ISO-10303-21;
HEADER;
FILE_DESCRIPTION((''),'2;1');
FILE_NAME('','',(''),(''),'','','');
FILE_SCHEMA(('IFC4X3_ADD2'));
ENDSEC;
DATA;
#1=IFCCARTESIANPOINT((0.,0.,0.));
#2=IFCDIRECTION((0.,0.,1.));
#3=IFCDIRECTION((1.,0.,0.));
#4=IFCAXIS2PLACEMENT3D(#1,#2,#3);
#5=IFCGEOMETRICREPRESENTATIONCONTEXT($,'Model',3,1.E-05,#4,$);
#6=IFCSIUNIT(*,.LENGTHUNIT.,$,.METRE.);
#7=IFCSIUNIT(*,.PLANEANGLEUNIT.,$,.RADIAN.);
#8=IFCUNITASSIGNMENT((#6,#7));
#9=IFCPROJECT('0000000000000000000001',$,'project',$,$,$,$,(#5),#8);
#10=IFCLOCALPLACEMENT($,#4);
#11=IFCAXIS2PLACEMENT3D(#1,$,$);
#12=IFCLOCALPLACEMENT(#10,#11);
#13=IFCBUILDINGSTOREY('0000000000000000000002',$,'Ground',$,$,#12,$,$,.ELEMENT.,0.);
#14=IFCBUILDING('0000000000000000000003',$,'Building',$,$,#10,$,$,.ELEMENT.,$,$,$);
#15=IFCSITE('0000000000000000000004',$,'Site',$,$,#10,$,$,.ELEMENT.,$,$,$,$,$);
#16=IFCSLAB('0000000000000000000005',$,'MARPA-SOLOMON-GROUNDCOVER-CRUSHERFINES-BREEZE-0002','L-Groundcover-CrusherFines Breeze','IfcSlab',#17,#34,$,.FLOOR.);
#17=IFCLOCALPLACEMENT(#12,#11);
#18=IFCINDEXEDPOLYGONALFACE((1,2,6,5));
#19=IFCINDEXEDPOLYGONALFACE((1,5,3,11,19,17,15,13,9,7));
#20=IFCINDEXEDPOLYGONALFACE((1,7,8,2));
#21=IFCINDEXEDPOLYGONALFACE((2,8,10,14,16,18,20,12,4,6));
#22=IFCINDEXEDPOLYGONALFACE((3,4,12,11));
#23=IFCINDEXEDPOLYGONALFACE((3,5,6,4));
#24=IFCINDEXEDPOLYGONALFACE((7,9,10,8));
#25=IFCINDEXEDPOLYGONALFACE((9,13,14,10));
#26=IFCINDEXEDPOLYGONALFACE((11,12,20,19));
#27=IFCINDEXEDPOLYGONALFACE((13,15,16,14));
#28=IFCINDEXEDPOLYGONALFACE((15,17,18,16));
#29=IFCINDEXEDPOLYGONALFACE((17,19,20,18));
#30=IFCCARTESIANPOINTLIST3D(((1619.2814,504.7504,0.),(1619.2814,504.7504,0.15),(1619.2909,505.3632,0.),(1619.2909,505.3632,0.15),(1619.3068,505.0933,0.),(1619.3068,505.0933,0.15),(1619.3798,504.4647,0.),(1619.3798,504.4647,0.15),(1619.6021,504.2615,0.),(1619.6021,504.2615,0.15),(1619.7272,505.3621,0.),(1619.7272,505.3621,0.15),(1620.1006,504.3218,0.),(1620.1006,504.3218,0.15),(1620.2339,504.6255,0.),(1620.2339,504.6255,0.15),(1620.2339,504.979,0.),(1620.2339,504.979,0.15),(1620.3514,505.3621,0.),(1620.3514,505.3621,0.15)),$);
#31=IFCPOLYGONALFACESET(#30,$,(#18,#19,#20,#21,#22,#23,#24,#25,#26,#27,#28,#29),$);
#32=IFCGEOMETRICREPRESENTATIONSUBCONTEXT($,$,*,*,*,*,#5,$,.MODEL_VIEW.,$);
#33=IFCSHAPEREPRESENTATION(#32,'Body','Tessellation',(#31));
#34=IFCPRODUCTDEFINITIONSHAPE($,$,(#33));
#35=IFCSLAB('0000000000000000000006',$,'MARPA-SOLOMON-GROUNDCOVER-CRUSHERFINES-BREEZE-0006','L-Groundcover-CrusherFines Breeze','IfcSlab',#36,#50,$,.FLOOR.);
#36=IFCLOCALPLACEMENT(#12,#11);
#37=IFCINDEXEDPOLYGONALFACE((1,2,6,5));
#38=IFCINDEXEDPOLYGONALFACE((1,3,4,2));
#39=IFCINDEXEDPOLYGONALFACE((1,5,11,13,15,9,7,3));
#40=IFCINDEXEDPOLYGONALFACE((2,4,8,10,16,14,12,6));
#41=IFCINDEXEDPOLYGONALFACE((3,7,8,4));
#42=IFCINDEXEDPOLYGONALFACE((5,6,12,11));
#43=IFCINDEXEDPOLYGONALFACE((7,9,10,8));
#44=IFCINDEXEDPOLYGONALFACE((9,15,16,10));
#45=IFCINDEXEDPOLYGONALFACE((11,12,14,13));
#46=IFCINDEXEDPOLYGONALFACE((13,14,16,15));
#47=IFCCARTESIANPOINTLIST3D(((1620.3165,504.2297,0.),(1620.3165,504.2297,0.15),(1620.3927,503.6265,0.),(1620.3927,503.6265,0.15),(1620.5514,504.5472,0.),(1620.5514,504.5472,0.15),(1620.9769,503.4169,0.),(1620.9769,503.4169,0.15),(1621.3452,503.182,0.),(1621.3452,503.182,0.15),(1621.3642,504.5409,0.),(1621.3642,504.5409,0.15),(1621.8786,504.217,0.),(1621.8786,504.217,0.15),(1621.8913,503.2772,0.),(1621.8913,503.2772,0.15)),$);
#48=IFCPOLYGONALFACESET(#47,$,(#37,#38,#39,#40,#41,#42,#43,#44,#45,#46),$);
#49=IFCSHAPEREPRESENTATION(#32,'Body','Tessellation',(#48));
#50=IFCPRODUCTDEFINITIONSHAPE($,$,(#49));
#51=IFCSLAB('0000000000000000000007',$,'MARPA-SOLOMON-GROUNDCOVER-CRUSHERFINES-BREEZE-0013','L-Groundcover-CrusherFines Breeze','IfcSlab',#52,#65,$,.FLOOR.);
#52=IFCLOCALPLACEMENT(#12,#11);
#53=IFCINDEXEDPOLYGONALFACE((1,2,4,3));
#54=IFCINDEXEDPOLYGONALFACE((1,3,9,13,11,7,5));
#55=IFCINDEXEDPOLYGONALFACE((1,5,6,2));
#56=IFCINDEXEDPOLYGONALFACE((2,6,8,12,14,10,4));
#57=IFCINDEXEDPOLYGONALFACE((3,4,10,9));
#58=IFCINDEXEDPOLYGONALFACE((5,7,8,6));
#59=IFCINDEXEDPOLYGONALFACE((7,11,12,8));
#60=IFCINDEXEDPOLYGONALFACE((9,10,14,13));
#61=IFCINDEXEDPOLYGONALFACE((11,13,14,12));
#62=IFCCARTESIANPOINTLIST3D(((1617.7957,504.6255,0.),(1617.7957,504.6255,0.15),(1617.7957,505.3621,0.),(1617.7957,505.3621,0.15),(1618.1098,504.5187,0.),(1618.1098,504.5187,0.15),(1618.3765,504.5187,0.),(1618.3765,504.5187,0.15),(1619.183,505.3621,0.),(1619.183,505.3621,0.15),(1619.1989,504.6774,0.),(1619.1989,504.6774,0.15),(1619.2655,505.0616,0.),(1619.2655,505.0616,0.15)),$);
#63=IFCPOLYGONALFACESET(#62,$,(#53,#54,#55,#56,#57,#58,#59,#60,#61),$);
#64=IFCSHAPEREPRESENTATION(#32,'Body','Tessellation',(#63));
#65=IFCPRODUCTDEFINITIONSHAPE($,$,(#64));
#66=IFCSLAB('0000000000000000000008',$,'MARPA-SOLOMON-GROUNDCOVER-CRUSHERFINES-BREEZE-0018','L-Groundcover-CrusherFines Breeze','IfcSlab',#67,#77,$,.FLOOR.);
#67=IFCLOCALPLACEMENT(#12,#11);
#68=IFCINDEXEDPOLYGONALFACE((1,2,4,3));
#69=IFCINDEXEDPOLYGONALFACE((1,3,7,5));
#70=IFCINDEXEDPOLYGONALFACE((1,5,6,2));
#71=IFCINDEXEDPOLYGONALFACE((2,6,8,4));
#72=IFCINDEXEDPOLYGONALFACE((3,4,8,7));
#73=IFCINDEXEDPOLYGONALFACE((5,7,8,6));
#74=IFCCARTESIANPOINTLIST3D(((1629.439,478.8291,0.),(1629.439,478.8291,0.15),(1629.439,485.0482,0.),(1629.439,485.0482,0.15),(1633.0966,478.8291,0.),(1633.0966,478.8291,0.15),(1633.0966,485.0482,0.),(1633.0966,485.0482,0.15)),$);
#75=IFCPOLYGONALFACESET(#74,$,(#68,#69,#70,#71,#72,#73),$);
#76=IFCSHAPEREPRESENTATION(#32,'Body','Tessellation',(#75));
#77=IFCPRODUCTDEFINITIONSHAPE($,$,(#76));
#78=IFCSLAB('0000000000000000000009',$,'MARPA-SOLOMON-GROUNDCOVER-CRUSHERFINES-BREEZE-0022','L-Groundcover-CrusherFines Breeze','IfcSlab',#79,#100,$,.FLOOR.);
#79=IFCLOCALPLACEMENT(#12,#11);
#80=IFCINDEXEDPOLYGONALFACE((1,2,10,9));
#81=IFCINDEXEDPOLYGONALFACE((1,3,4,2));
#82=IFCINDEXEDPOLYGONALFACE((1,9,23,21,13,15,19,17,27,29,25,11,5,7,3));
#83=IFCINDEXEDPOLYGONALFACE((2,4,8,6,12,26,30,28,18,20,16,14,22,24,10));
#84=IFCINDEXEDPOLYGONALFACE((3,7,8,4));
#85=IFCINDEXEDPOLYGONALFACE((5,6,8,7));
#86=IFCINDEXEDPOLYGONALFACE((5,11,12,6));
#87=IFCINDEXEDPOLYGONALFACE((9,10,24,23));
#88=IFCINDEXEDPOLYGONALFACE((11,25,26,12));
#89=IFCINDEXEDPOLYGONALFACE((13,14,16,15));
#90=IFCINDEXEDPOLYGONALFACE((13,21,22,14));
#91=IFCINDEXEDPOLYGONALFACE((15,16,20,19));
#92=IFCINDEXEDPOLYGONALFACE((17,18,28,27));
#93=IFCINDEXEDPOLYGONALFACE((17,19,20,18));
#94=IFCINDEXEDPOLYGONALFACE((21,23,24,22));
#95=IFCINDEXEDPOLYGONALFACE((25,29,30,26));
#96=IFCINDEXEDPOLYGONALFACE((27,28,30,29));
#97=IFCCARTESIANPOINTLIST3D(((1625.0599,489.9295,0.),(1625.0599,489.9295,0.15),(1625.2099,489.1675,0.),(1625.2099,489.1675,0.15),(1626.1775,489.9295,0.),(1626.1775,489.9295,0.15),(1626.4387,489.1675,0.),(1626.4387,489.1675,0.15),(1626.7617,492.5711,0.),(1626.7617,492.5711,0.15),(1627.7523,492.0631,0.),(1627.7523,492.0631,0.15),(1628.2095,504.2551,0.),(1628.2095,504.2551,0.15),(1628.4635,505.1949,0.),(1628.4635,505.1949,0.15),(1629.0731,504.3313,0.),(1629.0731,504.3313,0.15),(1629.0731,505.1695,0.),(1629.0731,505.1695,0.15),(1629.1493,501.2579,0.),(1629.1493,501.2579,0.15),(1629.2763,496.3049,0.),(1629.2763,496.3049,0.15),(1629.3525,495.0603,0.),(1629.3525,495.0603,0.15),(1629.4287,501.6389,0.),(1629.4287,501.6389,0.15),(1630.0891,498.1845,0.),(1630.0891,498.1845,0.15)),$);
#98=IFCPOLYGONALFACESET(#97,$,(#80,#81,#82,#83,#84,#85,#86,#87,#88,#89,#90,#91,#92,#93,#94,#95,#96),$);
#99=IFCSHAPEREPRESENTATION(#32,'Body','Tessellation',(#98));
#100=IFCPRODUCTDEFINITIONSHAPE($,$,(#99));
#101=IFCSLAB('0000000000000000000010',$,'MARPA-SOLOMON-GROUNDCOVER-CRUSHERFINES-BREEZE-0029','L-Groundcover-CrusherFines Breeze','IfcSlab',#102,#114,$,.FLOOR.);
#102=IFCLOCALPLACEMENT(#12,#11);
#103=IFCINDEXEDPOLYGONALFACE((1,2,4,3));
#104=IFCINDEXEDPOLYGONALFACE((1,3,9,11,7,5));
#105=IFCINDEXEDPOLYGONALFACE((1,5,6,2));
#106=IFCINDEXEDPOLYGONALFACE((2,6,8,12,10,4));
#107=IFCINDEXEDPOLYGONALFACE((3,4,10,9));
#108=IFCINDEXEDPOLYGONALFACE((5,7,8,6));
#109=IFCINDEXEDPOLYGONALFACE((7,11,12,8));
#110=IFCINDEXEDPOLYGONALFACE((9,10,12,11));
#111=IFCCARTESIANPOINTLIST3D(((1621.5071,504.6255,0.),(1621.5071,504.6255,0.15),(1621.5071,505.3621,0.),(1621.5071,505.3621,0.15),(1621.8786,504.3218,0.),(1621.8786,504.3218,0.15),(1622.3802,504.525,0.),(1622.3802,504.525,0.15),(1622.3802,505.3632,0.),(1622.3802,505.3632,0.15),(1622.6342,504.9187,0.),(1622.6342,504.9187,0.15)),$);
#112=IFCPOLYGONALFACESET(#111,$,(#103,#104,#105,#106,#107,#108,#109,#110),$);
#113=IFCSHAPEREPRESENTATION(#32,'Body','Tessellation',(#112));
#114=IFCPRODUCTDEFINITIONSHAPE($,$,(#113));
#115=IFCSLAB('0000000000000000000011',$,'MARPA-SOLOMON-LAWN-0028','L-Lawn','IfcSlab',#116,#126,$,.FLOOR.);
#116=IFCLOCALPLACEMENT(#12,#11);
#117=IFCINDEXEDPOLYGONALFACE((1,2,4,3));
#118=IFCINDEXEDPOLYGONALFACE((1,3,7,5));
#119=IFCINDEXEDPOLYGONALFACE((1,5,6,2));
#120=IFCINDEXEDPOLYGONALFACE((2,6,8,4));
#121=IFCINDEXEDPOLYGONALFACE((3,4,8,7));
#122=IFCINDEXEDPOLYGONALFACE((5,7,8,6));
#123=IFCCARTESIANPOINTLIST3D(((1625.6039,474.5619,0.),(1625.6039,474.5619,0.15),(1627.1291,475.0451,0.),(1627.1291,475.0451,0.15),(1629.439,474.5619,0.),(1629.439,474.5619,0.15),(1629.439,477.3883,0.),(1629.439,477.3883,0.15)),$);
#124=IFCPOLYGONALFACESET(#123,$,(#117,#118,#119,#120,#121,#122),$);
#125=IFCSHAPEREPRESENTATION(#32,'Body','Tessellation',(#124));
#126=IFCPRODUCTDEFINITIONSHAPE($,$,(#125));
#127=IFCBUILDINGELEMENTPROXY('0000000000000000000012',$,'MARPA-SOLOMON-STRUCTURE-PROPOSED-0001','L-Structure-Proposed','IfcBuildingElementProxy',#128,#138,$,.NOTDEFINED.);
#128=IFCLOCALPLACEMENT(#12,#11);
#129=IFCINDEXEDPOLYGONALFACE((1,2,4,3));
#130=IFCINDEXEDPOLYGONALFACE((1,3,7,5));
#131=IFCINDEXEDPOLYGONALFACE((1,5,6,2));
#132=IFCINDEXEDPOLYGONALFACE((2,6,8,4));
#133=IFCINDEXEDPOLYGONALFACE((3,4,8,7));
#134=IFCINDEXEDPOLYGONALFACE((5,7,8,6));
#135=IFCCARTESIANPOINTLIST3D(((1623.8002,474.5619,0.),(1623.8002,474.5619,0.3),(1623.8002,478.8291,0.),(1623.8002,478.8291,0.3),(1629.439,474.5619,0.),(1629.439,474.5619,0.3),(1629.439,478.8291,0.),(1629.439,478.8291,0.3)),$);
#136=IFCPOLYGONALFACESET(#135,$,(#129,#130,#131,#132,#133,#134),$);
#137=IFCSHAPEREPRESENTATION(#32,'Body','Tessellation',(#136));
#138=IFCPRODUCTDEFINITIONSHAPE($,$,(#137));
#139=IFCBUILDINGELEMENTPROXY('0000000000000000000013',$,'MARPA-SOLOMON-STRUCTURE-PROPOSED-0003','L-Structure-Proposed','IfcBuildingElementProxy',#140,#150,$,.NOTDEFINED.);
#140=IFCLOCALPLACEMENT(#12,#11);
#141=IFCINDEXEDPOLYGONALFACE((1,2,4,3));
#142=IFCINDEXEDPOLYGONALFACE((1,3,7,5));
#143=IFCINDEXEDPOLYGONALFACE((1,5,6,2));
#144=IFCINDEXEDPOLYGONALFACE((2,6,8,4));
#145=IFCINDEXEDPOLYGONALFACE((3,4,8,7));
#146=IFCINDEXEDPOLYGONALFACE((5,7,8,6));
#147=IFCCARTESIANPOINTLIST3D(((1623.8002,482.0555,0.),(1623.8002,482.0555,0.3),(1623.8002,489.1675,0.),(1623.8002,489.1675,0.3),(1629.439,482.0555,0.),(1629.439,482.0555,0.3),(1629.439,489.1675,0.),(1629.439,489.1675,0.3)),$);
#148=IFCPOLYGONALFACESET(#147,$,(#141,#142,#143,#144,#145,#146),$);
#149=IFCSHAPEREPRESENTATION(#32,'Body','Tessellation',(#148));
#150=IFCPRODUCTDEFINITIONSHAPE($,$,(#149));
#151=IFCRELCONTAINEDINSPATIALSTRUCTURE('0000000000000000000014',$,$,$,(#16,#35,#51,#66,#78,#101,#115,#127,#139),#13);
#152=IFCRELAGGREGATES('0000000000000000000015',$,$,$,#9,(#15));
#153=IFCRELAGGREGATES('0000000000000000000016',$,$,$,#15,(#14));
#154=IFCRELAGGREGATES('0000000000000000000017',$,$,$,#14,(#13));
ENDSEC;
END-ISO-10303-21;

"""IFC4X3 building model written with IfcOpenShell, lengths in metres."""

from ifc_helpers import new_model, si_unit, frame, origin, origin_with_axes, place, context, subcontext, project, spatial, polyline, outline, extrude, element, save


model = new_model("IFC4X3")

# Units and contexts
model_context = context("Model", 3, precision=1e-05, world=origin_with_axes())
sub_context = subcontext(model_context, None, None, "MODEL_VIEW")
ifc_project = project(units=[si_unit("LENGTHUNIT", "METRE"), si_unit("PLANEANGLEUNIT", "RADIAN")], contexts=[model_context])

# Site, building, storey
placement = place(None, origin_with_axes())
site = spatial("IfcSite", under=ifc_project, at=placement, Name="Site", CompositionType="ELEMENT")
building = spatial("IfcBuilding", under=site, at=placement, Name="Building", CompositionType="ELEMENT")
storey_placement = place(placement, origin())
storey = spatial("IfcBuildingStorey", under=building, at=storey_placement, Name="Ground", CompositionType="ELEMENT", Elevation=0.0)

# Slabs
slab_1_placement = place(storey_placement, frame((1619.2814, 504.2615, 0.0)))
element("IfcSlab", 1, at=slab_1_placement, inside=storey, Name="MARPA-SOLOMON-GROUNDCOVER-CRUSHERFINES-BREEZE-0002", Description="L-Groundcover-CrusherFines Breeze", ObjectType="IfcSlab", PredefinedType="FLOOR", context=sub_context, shape_type="SweptSolid", body=[
    extrude(outline(polyline([(1.07, 1.1006), (0.9525, 0.7175), (0.9525, 0.364), (0.8192, 0.0603), (0.3207, 0.0), (0.0984, 0.2032), (0.0, 0.4889), (0.0254, 0.8318), (0.0095, 1.1017), (0.4458, 1.1006), (1.07, 1.1006)])), origin(), (0.0, 0.0, 1.0), 0.15),
])
slab_2_placement = place(storey_placement, frame((1620.3165, 503.182, 0.0)))
element("IfcSlab", 2, at=slab_2_placement, inside=storey, Name="MARPA-SOLOMON-GROUNDCOVER-CRUSHERFINES-BREEZE-0006", Description="L-Groundcover-CrusherFines Breeze", ObjectType="IfcSlab", PredefinedType="FLOOR", context=sub_context, shape_type="SweptSolid", body=[
    extrude(outline(polyline([(1.0477, 1.3589), (0.2349, 1.3653), (0.0, 1.0478), (0.0762, 0.4445), (0.6604, 0.2349), (1.0287, 0.0), (1.5748, 0.0952), (1.5621, 1.035), (1.0477, 1.3589)])), origin(), (0.0, 0.0, 1.0), 0.15),
])
slab_3_placement = place(storey_placement, frame((1617.7957, 504.5187, 0.0)))
element("IfcSlab", 3, at=slab_3_placement, inside=storey, Name="MARPA-SOLOMON-GROUNDCOVER-CRUSHERFINES-BREEZE-0013", Description="L-Groundcover-CrusherFines Breeze", ObjectType="IfcSlab", PredefinedType="FLOOR", context=sub_context, shape_type="SweptSolid", body=[
    extrude(outline(polyline([(0.0, 0.8434), (0.0, 0.1068), (0.3141, 0.0), (0.5808, 0.0), (1.4031, 0.1587), (1.4698, 0.5429), (1.3872, 0.8434), (0.0, 0.8434)])), origin(), (0.0, 0.0, 1.0), 0.15),
])
slab_4_placement = place(storey_placement, frame((1629.439, 478.8291, 0.0)))
element("IfcSlab", 4, at=slab_4_placement, inside=storey, Name="MARPA-SOLOMON-GROUNDCOVER-CRUSHERFINES-BREEZE-0018", Description="L-Groundcover-CrusherFines Breeze", ObjectType="IfcSlab", PredefinedType="FLOOR", context=sub_context, shape_type="SweptSolid", body=[
    extrude(outline(polyline([(0.0, 6.2191), (3.6576, 6.2191), (3.6576, 0.0), (0.0, 0.0), (0.0, 6.2191)])), origin(), (0.0, 0.0, 1.0), 0.15),
])
slab_5_placement = place(storey_placement, frame((1625.0599, 489.1675, 0.0)))
element("IfcSlab", 5, at=slab_5_placement, inside=storey, Name="MARPA-SOLOMON-GROUNDCOVER-CRUSHERFINES-BREEZE-0022", Description="L-Groundcover-CrusherFines Breeze", ObjectType="IfcSlab", PredefinedType="FLOOR", context=sub_context, shape_type="SweptSolid", body=[
    extrude(outline(polyline([(0.15, 0.0), (0.0, 0.762), (1.7018, 3.4036), (4.2164, 7.1374), (4.0894, 12.0904), (3.1496, 15.0876), (3.4036, 16.0274), (4.0132, 16.002), (4.0132, 15.1638), (4.3688, 12.4714), (5.0292, 9.017), (4.2926, 5.8928), (2.6924, 2.8956), (1.1176, 0.762), (1.3788, 0.0), (0.15, 0.0)])), origin(), (0.0, 0.0, 1.0), 0.15),
])
slab_6_placement = place(storey_placement, frame((1621.5071, 504.3218, 0.0)))
element("IfcSlab", 6, at=slab_6_placement, inside=storey, Name="MARPA-SOLOMON-GROUNDCOVER-CRUSHERFINES-BREEZE-0029", Description="L-Groundcover-CrusherFines Breeze", ObjectType="IfcSlab", PredefinedType="FLOOR", context=sub_context, shape_type="SweptSolid", body=[
    extrude(outline(polyline([(0.0, 1.0403), (0.0, 0.3037), (0.3715, 0.0), (0.8731, 0.2032), (1.1271, 0.5969), (0.8731, 1.0414), (0.0, 1.0403)])), origin(), (0.0, 0.0, 1.0), 0.15),
])
slab_7_placement = place(storey_placement, frame((1625.6039, 474.5619, 0.0)))
element("IfcSlab", 7, at=slab_7_placement, inside=storey, Name="MARPA-SOLOMON-LAWN-0028", Description="L-Lawn", ObjectType="IfcSlab", PredefinedType="FLOOR", context=sub_context, shape_type="SweptSolid", body=[
    extrude(outline(polyline([(3.8351, 0.0), (3.8351, 2.8263), (1.5252, 0.4832), (0.0, 0.0), (3.8351, 0.0)])), origin(), (0.0, 0.0, 1.0), 0.15),
])

# Building element proxies
proxy_1_placement = place(placement, frame((1623.8002, 474.5619, 0.0)))
element("IfcBuildingElementProxy", 8, at=proxy_1_placement, inside=storey, Name="MARPA-SOLOMON-STRUCTURE-PROPOSED-0001", Description="L-Structure-Proposed", ObjectType="IfcBuildingElementProxy", PredefinedType="NOTDEFINED", context=sub_context, shape_type="SweptSolid", body=[
    extrude(outline(polyline([(0.0, 4.2672), (5.6388, 4.2672), (5.6388, 0.0), (0.0, 0.0), (0.0, 4.2672)])), origin(), (0.0, 0.0, 1.0), 0.3),
])
proxy_2_placement = place(placement, frame((1623.8002, 482.0555, 0.0)))
element("IfcBuildingElementProxy", 9, at=proxy_2_placement, inside=storey, Name="MARPA-SOLOMON-STRUCTURE-PROPOSED-0003", Description="L-Structure-Proposed", ObjectType="IfcBuildingElementProxy", PredefinedType="NOTDEFINED", context=sub_context, shape_type="SweptSolid", body=[
    extrude(outline(polyline([(0.0, 7.112), (5.6388, 7.112), (5.6388, 0.0), (0.0, 0.0), (0.0, 7.112)])), origin(), (0.0, 0.0, 1.0), 0.3),
])

save(model, "model.ifc")
